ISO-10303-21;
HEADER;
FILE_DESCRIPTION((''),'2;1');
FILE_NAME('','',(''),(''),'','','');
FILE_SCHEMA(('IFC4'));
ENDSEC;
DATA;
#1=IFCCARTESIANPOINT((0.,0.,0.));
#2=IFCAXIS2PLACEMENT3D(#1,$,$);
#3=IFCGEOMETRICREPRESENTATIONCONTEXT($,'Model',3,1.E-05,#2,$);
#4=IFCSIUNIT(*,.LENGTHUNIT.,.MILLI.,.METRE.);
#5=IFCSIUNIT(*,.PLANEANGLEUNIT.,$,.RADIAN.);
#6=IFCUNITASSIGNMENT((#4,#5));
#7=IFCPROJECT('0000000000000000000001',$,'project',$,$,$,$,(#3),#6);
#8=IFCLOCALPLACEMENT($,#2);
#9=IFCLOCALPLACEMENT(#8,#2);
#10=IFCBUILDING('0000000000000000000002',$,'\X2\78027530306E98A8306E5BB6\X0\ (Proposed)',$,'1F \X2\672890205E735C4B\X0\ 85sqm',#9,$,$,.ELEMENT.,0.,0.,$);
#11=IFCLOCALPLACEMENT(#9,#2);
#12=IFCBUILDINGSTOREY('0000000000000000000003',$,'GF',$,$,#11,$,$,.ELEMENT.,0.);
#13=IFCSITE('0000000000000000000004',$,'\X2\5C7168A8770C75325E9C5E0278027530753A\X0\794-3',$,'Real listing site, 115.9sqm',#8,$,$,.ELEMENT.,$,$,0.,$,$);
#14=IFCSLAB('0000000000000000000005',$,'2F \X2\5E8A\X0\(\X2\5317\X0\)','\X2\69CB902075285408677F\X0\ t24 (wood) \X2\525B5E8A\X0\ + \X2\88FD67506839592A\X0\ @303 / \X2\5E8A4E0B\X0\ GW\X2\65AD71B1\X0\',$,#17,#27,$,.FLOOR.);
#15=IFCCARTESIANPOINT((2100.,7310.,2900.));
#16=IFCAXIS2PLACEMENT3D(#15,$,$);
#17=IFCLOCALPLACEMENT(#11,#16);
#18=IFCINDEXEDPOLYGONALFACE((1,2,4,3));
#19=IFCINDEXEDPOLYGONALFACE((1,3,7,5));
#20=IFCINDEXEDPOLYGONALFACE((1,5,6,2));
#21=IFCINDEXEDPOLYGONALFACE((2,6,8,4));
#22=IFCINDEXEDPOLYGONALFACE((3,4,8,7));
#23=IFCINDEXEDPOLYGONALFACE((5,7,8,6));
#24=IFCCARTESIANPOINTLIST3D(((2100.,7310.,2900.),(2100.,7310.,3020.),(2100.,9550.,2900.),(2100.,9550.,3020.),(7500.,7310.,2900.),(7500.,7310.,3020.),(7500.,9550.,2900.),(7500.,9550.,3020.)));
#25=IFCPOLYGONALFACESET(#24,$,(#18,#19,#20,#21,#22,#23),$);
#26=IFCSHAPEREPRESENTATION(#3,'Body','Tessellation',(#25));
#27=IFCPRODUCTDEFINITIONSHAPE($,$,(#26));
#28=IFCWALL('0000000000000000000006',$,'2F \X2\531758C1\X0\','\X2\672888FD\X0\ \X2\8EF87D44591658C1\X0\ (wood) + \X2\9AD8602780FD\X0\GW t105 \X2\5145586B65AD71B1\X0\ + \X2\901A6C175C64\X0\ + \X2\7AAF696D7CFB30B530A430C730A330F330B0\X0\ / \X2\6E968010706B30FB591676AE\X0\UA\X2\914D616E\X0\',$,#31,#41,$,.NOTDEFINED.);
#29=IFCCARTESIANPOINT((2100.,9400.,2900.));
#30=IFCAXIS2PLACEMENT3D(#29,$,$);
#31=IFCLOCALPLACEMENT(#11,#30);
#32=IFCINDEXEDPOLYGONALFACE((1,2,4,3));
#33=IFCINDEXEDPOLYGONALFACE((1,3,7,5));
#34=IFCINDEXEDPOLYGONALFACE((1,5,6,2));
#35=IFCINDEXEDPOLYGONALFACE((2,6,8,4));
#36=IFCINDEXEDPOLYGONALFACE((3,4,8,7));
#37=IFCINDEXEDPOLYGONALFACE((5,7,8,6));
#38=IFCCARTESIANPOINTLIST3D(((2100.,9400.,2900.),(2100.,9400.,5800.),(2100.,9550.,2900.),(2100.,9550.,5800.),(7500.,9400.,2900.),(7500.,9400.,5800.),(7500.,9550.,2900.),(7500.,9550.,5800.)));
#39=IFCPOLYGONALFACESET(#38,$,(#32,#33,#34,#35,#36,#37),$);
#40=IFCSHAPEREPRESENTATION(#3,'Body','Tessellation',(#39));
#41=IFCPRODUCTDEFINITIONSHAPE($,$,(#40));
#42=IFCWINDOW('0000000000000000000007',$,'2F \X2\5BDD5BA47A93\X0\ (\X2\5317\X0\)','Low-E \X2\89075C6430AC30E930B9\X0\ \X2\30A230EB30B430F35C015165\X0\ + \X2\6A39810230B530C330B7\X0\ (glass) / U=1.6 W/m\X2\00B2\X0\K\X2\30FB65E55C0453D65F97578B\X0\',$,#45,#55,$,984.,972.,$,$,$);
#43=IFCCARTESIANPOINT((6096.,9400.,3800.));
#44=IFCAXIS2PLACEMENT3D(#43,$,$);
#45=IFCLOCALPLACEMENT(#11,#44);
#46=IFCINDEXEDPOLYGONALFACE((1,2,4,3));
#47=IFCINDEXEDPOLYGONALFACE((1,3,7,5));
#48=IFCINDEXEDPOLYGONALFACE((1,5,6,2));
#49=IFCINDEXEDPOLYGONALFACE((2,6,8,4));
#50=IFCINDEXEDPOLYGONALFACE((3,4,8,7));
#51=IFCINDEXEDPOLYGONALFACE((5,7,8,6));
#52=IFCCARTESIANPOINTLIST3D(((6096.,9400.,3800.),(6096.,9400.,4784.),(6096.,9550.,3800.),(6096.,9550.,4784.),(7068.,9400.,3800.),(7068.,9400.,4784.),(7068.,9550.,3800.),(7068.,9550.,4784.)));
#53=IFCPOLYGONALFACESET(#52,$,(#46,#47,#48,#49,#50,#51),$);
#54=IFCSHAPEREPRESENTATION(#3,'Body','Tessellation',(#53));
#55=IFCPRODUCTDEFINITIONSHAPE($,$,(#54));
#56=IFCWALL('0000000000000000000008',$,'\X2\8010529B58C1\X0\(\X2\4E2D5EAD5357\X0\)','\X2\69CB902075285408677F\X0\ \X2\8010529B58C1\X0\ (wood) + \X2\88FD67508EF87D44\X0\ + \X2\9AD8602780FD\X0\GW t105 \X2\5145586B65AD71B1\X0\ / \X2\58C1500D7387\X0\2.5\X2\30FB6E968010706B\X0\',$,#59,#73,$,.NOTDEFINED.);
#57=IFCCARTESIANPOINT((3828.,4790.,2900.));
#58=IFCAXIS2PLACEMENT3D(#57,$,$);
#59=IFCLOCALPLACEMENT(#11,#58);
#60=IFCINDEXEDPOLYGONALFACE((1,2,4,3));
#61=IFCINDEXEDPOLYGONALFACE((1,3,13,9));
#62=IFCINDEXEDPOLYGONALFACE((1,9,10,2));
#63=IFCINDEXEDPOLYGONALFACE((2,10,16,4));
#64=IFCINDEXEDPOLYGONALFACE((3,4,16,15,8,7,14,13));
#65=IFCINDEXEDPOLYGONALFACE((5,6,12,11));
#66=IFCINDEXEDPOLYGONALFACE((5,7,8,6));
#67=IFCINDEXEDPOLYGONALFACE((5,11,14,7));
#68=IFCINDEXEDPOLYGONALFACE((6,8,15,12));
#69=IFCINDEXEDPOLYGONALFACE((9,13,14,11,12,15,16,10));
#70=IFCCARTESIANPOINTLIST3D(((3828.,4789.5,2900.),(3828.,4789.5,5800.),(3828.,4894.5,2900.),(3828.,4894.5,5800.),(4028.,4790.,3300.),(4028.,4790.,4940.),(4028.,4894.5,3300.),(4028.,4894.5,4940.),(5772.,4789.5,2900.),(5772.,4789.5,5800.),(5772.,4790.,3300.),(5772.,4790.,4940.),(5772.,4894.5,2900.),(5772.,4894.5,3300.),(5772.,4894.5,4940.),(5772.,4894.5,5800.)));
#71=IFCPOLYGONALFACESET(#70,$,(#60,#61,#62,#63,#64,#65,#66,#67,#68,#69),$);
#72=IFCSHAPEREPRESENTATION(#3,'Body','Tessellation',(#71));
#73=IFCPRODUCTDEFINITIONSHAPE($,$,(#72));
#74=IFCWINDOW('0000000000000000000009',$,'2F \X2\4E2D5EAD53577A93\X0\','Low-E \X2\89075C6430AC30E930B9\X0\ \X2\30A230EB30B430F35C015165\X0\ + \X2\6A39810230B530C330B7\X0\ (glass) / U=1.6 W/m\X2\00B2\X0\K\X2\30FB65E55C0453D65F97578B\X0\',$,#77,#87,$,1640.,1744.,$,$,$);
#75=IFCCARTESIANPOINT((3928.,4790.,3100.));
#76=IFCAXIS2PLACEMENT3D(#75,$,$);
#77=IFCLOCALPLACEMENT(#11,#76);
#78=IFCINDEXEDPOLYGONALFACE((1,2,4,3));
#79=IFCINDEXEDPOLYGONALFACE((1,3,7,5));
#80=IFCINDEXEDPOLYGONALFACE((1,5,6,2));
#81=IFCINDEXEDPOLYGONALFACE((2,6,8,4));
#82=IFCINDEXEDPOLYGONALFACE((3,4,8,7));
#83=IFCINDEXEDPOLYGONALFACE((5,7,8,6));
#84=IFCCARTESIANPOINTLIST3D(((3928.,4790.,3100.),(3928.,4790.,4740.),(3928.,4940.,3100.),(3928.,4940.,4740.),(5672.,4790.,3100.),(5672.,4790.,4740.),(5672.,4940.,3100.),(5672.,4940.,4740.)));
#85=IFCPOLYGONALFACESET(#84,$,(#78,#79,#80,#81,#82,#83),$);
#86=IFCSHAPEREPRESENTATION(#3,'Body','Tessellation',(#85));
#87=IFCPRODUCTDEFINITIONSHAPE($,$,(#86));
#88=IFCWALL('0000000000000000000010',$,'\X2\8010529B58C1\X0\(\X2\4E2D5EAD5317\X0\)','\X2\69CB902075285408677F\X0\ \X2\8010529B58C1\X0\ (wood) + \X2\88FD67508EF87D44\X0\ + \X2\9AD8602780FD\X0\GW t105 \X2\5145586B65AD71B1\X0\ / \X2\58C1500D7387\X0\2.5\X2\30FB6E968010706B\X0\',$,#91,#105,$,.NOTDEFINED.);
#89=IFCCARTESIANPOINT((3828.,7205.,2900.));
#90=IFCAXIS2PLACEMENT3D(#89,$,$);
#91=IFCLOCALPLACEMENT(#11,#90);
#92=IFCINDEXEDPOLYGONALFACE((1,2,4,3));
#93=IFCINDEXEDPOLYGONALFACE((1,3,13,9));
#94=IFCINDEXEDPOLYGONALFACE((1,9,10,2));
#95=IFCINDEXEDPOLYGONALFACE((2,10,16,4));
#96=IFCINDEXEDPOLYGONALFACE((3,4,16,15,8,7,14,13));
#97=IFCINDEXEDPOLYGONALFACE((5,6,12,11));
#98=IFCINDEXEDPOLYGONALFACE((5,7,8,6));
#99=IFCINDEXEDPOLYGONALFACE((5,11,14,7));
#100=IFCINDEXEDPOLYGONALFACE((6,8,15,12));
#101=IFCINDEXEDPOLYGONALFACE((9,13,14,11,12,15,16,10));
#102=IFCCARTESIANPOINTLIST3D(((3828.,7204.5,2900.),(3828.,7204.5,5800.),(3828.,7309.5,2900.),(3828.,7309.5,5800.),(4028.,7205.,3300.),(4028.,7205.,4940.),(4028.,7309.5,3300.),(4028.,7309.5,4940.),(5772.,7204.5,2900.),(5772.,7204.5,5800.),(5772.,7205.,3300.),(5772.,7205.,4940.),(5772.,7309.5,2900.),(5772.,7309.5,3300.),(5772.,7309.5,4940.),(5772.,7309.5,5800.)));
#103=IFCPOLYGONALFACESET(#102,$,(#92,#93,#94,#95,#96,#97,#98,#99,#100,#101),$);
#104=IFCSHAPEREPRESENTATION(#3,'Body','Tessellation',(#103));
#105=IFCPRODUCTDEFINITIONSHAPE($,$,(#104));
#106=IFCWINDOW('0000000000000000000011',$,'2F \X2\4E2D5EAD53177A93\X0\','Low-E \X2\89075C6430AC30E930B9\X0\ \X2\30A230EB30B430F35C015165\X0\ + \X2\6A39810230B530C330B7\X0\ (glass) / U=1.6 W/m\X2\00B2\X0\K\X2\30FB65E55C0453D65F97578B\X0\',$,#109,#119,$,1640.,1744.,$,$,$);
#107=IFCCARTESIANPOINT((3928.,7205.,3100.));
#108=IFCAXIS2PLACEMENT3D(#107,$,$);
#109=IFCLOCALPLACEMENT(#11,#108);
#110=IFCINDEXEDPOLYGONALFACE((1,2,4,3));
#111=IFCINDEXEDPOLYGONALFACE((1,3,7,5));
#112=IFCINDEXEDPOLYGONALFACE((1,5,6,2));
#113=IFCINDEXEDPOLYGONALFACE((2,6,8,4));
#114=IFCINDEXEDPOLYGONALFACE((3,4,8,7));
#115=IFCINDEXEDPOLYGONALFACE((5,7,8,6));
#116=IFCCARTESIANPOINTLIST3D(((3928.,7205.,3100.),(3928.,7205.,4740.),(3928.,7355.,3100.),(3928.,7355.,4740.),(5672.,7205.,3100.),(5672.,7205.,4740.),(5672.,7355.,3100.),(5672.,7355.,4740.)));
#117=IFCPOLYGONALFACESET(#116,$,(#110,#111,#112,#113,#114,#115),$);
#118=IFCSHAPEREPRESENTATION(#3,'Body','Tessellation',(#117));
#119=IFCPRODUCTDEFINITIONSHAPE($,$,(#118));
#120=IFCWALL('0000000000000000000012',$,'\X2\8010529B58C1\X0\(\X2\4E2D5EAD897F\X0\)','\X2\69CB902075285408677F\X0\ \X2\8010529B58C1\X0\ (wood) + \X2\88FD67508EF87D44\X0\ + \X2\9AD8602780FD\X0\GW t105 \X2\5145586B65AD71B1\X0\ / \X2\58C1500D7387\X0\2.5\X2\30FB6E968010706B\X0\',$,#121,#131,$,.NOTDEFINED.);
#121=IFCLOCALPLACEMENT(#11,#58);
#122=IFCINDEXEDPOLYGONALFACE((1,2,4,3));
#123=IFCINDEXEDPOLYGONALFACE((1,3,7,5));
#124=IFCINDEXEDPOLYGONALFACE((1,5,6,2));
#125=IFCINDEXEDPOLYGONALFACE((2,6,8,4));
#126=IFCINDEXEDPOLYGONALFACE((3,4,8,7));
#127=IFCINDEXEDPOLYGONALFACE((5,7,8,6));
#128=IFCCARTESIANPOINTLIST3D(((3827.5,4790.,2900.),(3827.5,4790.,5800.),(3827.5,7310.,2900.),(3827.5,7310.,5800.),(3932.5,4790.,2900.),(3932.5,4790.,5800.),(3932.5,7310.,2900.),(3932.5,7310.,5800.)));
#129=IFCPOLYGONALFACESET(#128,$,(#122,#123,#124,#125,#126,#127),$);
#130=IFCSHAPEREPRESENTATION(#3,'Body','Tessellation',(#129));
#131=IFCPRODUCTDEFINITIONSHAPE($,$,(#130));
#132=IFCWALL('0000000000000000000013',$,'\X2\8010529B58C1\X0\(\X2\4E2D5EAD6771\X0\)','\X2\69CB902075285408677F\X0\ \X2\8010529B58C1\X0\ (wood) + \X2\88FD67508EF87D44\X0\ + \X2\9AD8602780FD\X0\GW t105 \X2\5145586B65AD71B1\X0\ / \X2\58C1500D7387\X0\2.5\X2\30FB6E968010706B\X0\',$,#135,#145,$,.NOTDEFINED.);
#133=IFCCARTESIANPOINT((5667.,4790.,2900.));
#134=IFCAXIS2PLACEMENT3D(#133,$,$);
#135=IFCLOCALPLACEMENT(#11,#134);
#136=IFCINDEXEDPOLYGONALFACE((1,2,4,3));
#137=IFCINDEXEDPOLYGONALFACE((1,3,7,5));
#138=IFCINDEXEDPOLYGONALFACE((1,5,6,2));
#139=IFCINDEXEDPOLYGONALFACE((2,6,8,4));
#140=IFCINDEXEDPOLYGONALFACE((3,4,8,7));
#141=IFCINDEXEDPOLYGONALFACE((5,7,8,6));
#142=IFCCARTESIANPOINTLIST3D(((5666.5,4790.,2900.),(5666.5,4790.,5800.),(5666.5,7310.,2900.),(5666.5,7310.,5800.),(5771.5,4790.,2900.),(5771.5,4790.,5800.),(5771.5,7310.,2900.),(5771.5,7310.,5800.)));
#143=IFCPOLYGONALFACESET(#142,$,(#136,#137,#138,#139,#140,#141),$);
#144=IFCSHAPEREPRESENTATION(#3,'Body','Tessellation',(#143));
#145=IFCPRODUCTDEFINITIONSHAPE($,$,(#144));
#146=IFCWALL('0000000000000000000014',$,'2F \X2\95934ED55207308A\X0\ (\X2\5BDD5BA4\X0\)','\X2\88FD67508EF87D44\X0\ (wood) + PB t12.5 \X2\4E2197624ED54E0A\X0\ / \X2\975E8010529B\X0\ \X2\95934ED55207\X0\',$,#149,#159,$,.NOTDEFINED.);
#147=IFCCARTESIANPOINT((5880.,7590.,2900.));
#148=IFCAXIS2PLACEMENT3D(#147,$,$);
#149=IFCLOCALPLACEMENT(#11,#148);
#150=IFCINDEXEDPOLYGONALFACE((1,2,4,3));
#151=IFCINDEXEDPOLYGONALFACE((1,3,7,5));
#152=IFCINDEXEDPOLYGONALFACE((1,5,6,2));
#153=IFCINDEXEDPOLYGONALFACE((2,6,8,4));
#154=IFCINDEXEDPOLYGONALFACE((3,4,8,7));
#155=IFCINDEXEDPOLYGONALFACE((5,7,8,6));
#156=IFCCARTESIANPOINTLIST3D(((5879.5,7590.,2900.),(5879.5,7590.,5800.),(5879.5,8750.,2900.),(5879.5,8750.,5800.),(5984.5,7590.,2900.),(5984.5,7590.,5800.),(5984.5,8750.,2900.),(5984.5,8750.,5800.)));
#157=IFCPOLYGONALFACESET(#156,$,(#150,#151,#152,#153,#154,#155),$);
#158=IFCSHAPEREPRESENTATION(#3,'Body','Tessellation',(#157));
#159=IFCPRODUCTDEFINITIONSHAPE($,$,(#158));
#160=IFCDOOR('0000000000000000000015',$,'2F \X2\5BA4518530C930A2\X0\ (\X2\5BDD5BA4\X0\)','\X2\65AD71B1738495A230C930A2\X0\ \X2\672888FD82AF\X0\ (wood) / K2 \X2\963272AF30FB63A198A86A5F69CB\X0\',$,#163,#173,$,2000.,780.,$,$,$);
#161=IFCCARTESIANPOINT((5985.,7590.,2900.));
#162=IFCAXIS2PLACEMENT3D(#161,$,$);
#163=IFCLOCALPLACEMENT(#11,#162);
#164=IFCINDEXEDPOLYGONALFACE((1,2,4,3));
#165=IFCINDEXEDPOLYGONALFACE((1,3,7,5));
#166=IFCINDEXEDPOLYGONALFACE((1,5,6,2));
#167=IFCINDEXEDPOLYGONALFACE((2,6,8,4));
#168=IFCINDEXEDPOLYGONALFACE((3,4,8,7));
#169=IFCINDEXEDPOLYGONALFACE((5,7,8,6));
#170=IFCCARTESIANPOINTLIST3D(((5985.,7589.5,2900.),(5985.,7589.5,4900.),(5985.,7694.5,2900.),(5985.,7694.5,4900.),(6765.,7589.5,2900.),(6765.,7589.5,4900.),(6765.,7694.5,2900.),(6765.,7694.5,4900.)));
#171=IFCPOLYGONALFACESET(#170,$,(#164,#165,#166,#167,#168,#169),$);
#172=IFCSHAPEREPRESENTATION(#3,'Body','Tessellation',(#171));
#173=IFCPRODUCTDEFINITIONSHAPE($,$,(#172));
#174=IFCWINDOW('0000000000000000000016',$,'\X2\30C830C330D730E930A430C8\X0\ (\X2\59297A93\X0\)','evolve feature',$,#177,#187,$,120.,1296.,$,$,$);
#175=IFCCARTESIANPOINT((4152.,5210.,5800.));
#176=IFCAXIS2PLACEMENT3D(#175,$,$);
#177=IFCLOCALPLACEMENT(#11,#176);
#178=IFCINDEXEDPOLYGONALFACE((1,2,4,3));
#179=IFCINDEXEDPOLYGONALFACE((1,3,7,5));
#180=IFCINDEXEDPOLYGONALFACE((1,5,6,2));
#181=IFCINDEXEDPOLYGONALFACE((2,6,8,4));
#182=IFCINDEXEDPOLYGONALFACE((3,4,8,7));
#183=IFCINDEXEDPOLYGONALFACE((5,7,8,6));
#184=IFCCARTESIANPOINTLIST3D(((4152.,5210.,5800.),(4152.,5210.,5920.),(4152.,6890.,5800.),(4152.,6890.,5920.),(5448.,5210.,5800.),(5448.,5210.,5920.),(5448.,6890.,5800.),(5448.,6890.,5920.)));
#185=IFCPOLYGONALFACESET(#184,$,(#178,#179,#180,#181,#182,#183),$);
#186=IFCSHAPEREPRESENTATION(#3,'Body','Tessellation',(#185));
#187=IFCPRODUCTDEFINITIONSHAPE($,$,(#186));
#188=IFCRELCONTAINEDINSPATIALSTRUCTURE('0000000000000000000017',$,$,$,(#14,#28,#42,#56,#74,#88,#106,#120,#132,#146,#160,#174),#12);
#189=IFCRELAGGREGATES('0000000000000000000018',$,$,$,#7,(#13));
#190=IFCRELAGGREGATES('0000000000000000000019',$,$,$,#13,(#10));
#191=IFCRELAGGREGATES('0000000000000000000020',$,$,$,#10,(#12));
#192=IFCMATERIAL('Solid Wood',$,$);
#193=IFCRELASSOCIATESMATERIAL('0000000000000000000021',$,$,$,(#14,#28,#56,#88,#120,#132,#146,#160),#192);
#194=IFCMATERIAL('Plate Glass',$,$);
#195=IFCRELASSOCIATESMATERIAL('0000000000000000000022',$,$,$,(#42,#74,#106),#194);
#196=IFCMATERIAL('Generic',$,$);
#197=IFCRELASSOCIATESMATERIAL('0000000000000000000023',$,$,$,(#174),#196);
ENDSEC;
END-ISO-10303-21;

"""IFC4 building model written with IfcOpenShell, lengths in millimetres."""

from ifc_helpers import new_model, si_unit, frame, frame_2d, origin, place, context, project, spatial, rectangle, extrude, material, element, fill, save


model = new_model("IFC4")

# Units and contexts
model_context = context("Model", 3, precision=1e-05, world=origin())
ifc_project = project(units=[si_unit("LENGTHUNIT", "METRE", prefix="MILLI"), si_unit("PLANEANGLEUNIT", "RADIAN")], contexts=[model_context])

# Site, building, storey
site_placement = place(None, origin())
site = spatial("IfcSite", under=ifc_project, at=site_placement, Name="山梨県甲府市砂田町794-3", ObjectType="Real listing site, 115.9sqm", CompositionType="ELEMENT", RefElevation=0.0)
building_placement = place(site_placement, origin())
building = spatial("IfcBuilding", under=site, at=building_placement, Name="砂田の風の家 (Proposed)", ObjectType="1F 木造平屋 85sqm", CompositionType="ELEMENT", ElevationOfRefHeight=0.0, ElevationOfTerrain=0.0)
storey_placement = place(building_placement, origin())
storey = spatial("IfcBuildingStorey", under=building, at=storey_placement, Name="GF", CompositionType="ELEMENT", Elevation=0.0)

# Slab
ifc_material_1 = material(Name="Solid Wood")
slab_placement = place(storey_placement, frame((2100.0, 7310.0, 2900.0)))
element("IfcSlab", 1, at=slab_placement, inside=storey, material=ifc_material_1, Name="2F 床(北)", Description="構造用合板 t24 (wood) 剛床 + 製材根太 @303 / 床下 GW断熱", PredefinedType="FLOOR", context=model_context, shape_type="SweptSolid", body=[
    extrude(rectangle(XDim=5400.0, YDim=2240.0, at=frame_2d((2700.0, 1120.0))), frame((2100.0, 7310.0, 2900.0)), (0.0, 0.0, 1.0), 120.0),
])

# Walls, openings, windows
wall_1_placement = place(storey_placement, frame((2100.0, 9400.0, 2900.0)))
wall_1 = element("IfcWall", 2, at=wall_1_placement, inside=storey, material=ifc_material_1, Name="2F 北壁", Description="木製 軸組外壁 (wood) + 高性能GW t105 充填断熱 + 通気層 + 窯業系サイディング / 準耐火・外皮UA配慮", PredefinedType="NOTDEFINED", context=model_context, shape_type="SweptSolid", body=[
    extrude(rectangle(XDim=5400.0, YDim=150.0, at=frame_2d((2700.0, 75.0))), frame((2100.0, 9400.0, 2900.0)), (0.0, 0.0, 1.0), 2900.0),
])
opening_1_placement = place(storey_placement, frame((6096.0, 9400.0, 3800.0)))
opening_1 = element("IfcOpeningElement", 3, at=opening_1_placement, cuts=wall_1, PredefinedType="NOTDEFINED", context=model_context, shape_type="SweptSolid", body=[
    extrude(rectangle(XDim=972.0, YDim=150.0, at=frame_2d((486.0, 75.0))), frame((6096.0, 9400.0, 3800.0)), (0.0, 0.0, 1.0), 984.0),
])
ifc_material_2 = material(Name="Plate Glass")
window_1_placement = place(storey_placement, frame((6096.0, 9400.0, 3800.0)))
window_1 = element("IfcWindow", 4, at=window_1_placement, inside=storey, material=ifc_material_2, Name="2F 寝室窓 (北)", Description="Low-E 複層ガラス アルゴン封入 + 樹脂サッシ (glass) / U=1.6 W/m²K・日射取得型", OverallHeight=984.0, OverallWidth=972.0, context=model_context, shape_type="SweptSolid", body=[
    extrude(rectangle(XDim=972.0, YDim=150.0, at=frame_2d((486.0, 75.0))), frame((6096.0, 9400.0, 3800.0)), (0.0, 0.0, 1.0), 984.0),
])
fill(opening_1, window_1)
wall_2_placement = place(storey_placement, frame((3828.0, 4790.0, 2900.0)))
wall_2 = element("IfcWall", 5, at=wall_2_placement, inside=storey, material=ifc_material_1, Name="耐力壁(中庭南)", Description="構造用合板 耐力壁 (wood) + 製材軸組 + 高性能GW t105 充填断熱 / 壁倍率2.5・準耐火", PredefinedType="NOTDEFINED", context=model_context, shape_type="SweptSolid", body=[
    extrude(rectangle(XDim=1944.0, YDim=105.0, at=frame_2d((972.0, 52.0))), frame((3828.0, 4790.0, 2900.0)), (0.0, 0.0, 1.0), 2900.0),
])
opening_2_placement = place(storey_placement, frame((3928.0, 4790.0, 3100.0)))
opening_2 = element("IfcOpeningElement", 6, at=opening_2_placement, cuts=wall_2, PredefinedType="NOTDEFINED", context=model_context, shape_type="SweptSolid", body=[
    extrude(rectangle(XDim=1744.0, YDim=150.0, at=frame_2d((872.0, 75.0))), frame((3928.0, 4790.0, 3100.0)), (0.0, 0.0, 1.0), 1640.0),
])
window_2_placement = place(storey_placement, frame((3928.0, 4790.0, 3100.0)))
window_2 = element("IfcWindow", 7, at=window_2_placement, inside=storey, material=ifc_material_2, Name="2F 中庭南窓", Description="Low-E 複層ガラス アルゴン封入 + 樹脂サッシ (glass) / U=1.6 W/m²K・日射取得型", OverallHeight=1640.0, OverallWidth=1744.0, context=model_context, shape_type="SweptSolid", body=[
    extrude(rectangle(XDim=1744.0, YDim=150.0, at=frame_2d((872.0, 75.0))), frame((3928.0, 4790.0, 3100.0)), (0.0, 0.0, 1.0), 1640.0),
])
fill(opening_2, window_2)
wall_3_placement = place(storey_placement, frame((3828.0, 7205.0, 2900.0)))
wall_3 = element("IfcWall", 8, at=wall_3_placement, inside=storey, material=ifc_material_1, Name="耐力壁(中庭北)", Description="構造用合板 耐力壁 (wood) + 製材軸組 + 高性能GW t105 充填断熱 / 壁倍率2.5・準耐火", PredefinedType="NOTDEFINED", context=model_context, shape_type="SweptSolid", body=[
    extrude(rectangle(XDim=1944.0, YDim=105.0, at=frame_2d((972.0, 52.0))), frame((3828.0, 7205.0, 2900.0)), (0.0, 0.0, 1.0), 2900.0),
])
opening_3_placement = place(storey_placement, frame((3928.0, 7205.0, 3100.0)))
opening_3 = element("IfcOpeningElement", 9, at=opening_3_placement, cuts=wall_3, PredefinedType="NOTDEFINED", context=model_context, shape_type="SweptSolid", body=[
    extrude(rectangle(XDim=1744.0, YDim=150.0, at=frame_2d((872.0, 75.0))), frame((3928.0, 7205.0, 3100.0)), (0.0, 0.0, 1.0), 1640.0),
])
window_3_placement = place(storey_placement, frame((3928.0, 7205.0, 3100.0)))
window_3 = element("IfcWindow", 10, at=window_3_placement, inside=storey, material=ifc_material_2, Name="2F 中庭北窓", Description="Low-E 複層ガラス アルゴン封入 + 樹脂サッシ (glass) / U=1.6 W/m²K・日射取得型", OverallHeight=1640.0, OverallWidth=1744.0, context=model_context, shape_type="SweptSolid", body=[
    extrude(rectangle(XDim=1744.0, YDim=150.0, at=frame_2d((872.0, 75.0))), frame((3928.0, 7205.0, 3100.0)), (0.0, 0.0, 1.0), 1640.0),
])
fill(opening_3, window_3)

# Walls
wall_4_placement = place(storey_placement, frame((3828.0, 4790.0, 2900.0)))
element("IfcWall", 11, at=wall_4_placement, inside=storey, material=ifc_material_1, Name="耐力壁(中庭西)", Description="構造用合板 耐力壁 (wood) + 製材軸組 + 高性能GW t105 充填断熱 / 壁倍率2.5・準耐火", PredefinedType="NOTDEFINED", context=model_context, shape_type="SweptSolid", body=[
    extrude(rectangle(XDim=105.0, YDim=2520.0, at=frame_2d((52.0, 1260.0))), frame((3828.0, 4790.0, 2900.0)), (0.0, 0.0, 1.0), 2900.0),
])
wall_5_placement = place(storey_placement, frame((5667.0, 4790.0, 2900.0)))
element("IfcWall", 12, at=wall_5_placement, inside=storey, material=ifc_material_1, Name="耐力壁(中庭東)", Description="構造用合板 耐力壁 (wood) + 製材軸組 + 高性能GW t105 充填断熱 / 壁倍率2.5・準耐火", PredefinedType="NOTDEFINED", context=model_context, shape_type="SweptSolid", body=[
    extrude(rectangle(XDim=105.0, YDim=2520.0, at=frame_2d((52.0, 1260.0))), frame((5667.0, 4790.0, 2900.0)), (0.0, 0.0, 1.0), 2900.0),
])
wall_6_placement = place(storey_placement, frame((5880.0, 7590.0, 2900.0)))
element("IfcWall", 13, at=wall_6_placement, inside=storey, material=ifc_material_1, Name="2F 間仕切り (寝室)", Description="製材軸組 (wood) + PB t12.5 両面仕上 / 非耐力 間仕切", PredefinedType="NOTDEFINED", context=model_context, shape_type="SweptSolid", body=[
    extrude(rectangle(XDim=105.0, YDim=1160.0, at=frame_2d((52.0, 580.0))), frame((5880.0, 7590.0, 2900.0)), (0.0, 0.0, 1.0), 2900.0),
])

# Door
door_placement = place(storey_placement, frame((5985.0, 7590.0, 2900.0)))
element("IfcDoor", 14, at=door_placement, inside=storey, material=ifc_material_1, Name="2F 室内ドア (寝室)", Description="断熱玄関ドア 木製芯 (wood) / K2 防犯・採風機構", OverallHeight=2000.0, OverallWidth=780.0, context=model_context, shape_type="SweptSolid", body=[
    extrude(rectangle(XDim=780.0, YDim=105.0, at=frame_2d((390.0, 52.0))), frame((5985.0, 7590.0, 2900.0)), (0.0, 0.0, 1.0), 2000.0),
])

# Window
ifc_material_3 = material(Name="Generic")
window_4_placement = place(storey_placement, frame((4152.0, 5210.0, 5800.0)))
element("IfcWindow", 15, at=window_4_placement, inside=storey, material=ifc_material_3, Name="トップライト (天窓)", Description="evolve feature", OverallHeight=120.0, OverallWidth=1296.0, context=model_context, shape_type="SweptSolid", body=[
    extrude(rectangle(XDim=1296.0, YDim=1680.0, at=frame_2d((648.0, 840.0))), frame((4152.0, 5210.0, 5800.0)), (0.0, 0.0, 1.0), 120.0),
])

save(model, "model.ifc")
